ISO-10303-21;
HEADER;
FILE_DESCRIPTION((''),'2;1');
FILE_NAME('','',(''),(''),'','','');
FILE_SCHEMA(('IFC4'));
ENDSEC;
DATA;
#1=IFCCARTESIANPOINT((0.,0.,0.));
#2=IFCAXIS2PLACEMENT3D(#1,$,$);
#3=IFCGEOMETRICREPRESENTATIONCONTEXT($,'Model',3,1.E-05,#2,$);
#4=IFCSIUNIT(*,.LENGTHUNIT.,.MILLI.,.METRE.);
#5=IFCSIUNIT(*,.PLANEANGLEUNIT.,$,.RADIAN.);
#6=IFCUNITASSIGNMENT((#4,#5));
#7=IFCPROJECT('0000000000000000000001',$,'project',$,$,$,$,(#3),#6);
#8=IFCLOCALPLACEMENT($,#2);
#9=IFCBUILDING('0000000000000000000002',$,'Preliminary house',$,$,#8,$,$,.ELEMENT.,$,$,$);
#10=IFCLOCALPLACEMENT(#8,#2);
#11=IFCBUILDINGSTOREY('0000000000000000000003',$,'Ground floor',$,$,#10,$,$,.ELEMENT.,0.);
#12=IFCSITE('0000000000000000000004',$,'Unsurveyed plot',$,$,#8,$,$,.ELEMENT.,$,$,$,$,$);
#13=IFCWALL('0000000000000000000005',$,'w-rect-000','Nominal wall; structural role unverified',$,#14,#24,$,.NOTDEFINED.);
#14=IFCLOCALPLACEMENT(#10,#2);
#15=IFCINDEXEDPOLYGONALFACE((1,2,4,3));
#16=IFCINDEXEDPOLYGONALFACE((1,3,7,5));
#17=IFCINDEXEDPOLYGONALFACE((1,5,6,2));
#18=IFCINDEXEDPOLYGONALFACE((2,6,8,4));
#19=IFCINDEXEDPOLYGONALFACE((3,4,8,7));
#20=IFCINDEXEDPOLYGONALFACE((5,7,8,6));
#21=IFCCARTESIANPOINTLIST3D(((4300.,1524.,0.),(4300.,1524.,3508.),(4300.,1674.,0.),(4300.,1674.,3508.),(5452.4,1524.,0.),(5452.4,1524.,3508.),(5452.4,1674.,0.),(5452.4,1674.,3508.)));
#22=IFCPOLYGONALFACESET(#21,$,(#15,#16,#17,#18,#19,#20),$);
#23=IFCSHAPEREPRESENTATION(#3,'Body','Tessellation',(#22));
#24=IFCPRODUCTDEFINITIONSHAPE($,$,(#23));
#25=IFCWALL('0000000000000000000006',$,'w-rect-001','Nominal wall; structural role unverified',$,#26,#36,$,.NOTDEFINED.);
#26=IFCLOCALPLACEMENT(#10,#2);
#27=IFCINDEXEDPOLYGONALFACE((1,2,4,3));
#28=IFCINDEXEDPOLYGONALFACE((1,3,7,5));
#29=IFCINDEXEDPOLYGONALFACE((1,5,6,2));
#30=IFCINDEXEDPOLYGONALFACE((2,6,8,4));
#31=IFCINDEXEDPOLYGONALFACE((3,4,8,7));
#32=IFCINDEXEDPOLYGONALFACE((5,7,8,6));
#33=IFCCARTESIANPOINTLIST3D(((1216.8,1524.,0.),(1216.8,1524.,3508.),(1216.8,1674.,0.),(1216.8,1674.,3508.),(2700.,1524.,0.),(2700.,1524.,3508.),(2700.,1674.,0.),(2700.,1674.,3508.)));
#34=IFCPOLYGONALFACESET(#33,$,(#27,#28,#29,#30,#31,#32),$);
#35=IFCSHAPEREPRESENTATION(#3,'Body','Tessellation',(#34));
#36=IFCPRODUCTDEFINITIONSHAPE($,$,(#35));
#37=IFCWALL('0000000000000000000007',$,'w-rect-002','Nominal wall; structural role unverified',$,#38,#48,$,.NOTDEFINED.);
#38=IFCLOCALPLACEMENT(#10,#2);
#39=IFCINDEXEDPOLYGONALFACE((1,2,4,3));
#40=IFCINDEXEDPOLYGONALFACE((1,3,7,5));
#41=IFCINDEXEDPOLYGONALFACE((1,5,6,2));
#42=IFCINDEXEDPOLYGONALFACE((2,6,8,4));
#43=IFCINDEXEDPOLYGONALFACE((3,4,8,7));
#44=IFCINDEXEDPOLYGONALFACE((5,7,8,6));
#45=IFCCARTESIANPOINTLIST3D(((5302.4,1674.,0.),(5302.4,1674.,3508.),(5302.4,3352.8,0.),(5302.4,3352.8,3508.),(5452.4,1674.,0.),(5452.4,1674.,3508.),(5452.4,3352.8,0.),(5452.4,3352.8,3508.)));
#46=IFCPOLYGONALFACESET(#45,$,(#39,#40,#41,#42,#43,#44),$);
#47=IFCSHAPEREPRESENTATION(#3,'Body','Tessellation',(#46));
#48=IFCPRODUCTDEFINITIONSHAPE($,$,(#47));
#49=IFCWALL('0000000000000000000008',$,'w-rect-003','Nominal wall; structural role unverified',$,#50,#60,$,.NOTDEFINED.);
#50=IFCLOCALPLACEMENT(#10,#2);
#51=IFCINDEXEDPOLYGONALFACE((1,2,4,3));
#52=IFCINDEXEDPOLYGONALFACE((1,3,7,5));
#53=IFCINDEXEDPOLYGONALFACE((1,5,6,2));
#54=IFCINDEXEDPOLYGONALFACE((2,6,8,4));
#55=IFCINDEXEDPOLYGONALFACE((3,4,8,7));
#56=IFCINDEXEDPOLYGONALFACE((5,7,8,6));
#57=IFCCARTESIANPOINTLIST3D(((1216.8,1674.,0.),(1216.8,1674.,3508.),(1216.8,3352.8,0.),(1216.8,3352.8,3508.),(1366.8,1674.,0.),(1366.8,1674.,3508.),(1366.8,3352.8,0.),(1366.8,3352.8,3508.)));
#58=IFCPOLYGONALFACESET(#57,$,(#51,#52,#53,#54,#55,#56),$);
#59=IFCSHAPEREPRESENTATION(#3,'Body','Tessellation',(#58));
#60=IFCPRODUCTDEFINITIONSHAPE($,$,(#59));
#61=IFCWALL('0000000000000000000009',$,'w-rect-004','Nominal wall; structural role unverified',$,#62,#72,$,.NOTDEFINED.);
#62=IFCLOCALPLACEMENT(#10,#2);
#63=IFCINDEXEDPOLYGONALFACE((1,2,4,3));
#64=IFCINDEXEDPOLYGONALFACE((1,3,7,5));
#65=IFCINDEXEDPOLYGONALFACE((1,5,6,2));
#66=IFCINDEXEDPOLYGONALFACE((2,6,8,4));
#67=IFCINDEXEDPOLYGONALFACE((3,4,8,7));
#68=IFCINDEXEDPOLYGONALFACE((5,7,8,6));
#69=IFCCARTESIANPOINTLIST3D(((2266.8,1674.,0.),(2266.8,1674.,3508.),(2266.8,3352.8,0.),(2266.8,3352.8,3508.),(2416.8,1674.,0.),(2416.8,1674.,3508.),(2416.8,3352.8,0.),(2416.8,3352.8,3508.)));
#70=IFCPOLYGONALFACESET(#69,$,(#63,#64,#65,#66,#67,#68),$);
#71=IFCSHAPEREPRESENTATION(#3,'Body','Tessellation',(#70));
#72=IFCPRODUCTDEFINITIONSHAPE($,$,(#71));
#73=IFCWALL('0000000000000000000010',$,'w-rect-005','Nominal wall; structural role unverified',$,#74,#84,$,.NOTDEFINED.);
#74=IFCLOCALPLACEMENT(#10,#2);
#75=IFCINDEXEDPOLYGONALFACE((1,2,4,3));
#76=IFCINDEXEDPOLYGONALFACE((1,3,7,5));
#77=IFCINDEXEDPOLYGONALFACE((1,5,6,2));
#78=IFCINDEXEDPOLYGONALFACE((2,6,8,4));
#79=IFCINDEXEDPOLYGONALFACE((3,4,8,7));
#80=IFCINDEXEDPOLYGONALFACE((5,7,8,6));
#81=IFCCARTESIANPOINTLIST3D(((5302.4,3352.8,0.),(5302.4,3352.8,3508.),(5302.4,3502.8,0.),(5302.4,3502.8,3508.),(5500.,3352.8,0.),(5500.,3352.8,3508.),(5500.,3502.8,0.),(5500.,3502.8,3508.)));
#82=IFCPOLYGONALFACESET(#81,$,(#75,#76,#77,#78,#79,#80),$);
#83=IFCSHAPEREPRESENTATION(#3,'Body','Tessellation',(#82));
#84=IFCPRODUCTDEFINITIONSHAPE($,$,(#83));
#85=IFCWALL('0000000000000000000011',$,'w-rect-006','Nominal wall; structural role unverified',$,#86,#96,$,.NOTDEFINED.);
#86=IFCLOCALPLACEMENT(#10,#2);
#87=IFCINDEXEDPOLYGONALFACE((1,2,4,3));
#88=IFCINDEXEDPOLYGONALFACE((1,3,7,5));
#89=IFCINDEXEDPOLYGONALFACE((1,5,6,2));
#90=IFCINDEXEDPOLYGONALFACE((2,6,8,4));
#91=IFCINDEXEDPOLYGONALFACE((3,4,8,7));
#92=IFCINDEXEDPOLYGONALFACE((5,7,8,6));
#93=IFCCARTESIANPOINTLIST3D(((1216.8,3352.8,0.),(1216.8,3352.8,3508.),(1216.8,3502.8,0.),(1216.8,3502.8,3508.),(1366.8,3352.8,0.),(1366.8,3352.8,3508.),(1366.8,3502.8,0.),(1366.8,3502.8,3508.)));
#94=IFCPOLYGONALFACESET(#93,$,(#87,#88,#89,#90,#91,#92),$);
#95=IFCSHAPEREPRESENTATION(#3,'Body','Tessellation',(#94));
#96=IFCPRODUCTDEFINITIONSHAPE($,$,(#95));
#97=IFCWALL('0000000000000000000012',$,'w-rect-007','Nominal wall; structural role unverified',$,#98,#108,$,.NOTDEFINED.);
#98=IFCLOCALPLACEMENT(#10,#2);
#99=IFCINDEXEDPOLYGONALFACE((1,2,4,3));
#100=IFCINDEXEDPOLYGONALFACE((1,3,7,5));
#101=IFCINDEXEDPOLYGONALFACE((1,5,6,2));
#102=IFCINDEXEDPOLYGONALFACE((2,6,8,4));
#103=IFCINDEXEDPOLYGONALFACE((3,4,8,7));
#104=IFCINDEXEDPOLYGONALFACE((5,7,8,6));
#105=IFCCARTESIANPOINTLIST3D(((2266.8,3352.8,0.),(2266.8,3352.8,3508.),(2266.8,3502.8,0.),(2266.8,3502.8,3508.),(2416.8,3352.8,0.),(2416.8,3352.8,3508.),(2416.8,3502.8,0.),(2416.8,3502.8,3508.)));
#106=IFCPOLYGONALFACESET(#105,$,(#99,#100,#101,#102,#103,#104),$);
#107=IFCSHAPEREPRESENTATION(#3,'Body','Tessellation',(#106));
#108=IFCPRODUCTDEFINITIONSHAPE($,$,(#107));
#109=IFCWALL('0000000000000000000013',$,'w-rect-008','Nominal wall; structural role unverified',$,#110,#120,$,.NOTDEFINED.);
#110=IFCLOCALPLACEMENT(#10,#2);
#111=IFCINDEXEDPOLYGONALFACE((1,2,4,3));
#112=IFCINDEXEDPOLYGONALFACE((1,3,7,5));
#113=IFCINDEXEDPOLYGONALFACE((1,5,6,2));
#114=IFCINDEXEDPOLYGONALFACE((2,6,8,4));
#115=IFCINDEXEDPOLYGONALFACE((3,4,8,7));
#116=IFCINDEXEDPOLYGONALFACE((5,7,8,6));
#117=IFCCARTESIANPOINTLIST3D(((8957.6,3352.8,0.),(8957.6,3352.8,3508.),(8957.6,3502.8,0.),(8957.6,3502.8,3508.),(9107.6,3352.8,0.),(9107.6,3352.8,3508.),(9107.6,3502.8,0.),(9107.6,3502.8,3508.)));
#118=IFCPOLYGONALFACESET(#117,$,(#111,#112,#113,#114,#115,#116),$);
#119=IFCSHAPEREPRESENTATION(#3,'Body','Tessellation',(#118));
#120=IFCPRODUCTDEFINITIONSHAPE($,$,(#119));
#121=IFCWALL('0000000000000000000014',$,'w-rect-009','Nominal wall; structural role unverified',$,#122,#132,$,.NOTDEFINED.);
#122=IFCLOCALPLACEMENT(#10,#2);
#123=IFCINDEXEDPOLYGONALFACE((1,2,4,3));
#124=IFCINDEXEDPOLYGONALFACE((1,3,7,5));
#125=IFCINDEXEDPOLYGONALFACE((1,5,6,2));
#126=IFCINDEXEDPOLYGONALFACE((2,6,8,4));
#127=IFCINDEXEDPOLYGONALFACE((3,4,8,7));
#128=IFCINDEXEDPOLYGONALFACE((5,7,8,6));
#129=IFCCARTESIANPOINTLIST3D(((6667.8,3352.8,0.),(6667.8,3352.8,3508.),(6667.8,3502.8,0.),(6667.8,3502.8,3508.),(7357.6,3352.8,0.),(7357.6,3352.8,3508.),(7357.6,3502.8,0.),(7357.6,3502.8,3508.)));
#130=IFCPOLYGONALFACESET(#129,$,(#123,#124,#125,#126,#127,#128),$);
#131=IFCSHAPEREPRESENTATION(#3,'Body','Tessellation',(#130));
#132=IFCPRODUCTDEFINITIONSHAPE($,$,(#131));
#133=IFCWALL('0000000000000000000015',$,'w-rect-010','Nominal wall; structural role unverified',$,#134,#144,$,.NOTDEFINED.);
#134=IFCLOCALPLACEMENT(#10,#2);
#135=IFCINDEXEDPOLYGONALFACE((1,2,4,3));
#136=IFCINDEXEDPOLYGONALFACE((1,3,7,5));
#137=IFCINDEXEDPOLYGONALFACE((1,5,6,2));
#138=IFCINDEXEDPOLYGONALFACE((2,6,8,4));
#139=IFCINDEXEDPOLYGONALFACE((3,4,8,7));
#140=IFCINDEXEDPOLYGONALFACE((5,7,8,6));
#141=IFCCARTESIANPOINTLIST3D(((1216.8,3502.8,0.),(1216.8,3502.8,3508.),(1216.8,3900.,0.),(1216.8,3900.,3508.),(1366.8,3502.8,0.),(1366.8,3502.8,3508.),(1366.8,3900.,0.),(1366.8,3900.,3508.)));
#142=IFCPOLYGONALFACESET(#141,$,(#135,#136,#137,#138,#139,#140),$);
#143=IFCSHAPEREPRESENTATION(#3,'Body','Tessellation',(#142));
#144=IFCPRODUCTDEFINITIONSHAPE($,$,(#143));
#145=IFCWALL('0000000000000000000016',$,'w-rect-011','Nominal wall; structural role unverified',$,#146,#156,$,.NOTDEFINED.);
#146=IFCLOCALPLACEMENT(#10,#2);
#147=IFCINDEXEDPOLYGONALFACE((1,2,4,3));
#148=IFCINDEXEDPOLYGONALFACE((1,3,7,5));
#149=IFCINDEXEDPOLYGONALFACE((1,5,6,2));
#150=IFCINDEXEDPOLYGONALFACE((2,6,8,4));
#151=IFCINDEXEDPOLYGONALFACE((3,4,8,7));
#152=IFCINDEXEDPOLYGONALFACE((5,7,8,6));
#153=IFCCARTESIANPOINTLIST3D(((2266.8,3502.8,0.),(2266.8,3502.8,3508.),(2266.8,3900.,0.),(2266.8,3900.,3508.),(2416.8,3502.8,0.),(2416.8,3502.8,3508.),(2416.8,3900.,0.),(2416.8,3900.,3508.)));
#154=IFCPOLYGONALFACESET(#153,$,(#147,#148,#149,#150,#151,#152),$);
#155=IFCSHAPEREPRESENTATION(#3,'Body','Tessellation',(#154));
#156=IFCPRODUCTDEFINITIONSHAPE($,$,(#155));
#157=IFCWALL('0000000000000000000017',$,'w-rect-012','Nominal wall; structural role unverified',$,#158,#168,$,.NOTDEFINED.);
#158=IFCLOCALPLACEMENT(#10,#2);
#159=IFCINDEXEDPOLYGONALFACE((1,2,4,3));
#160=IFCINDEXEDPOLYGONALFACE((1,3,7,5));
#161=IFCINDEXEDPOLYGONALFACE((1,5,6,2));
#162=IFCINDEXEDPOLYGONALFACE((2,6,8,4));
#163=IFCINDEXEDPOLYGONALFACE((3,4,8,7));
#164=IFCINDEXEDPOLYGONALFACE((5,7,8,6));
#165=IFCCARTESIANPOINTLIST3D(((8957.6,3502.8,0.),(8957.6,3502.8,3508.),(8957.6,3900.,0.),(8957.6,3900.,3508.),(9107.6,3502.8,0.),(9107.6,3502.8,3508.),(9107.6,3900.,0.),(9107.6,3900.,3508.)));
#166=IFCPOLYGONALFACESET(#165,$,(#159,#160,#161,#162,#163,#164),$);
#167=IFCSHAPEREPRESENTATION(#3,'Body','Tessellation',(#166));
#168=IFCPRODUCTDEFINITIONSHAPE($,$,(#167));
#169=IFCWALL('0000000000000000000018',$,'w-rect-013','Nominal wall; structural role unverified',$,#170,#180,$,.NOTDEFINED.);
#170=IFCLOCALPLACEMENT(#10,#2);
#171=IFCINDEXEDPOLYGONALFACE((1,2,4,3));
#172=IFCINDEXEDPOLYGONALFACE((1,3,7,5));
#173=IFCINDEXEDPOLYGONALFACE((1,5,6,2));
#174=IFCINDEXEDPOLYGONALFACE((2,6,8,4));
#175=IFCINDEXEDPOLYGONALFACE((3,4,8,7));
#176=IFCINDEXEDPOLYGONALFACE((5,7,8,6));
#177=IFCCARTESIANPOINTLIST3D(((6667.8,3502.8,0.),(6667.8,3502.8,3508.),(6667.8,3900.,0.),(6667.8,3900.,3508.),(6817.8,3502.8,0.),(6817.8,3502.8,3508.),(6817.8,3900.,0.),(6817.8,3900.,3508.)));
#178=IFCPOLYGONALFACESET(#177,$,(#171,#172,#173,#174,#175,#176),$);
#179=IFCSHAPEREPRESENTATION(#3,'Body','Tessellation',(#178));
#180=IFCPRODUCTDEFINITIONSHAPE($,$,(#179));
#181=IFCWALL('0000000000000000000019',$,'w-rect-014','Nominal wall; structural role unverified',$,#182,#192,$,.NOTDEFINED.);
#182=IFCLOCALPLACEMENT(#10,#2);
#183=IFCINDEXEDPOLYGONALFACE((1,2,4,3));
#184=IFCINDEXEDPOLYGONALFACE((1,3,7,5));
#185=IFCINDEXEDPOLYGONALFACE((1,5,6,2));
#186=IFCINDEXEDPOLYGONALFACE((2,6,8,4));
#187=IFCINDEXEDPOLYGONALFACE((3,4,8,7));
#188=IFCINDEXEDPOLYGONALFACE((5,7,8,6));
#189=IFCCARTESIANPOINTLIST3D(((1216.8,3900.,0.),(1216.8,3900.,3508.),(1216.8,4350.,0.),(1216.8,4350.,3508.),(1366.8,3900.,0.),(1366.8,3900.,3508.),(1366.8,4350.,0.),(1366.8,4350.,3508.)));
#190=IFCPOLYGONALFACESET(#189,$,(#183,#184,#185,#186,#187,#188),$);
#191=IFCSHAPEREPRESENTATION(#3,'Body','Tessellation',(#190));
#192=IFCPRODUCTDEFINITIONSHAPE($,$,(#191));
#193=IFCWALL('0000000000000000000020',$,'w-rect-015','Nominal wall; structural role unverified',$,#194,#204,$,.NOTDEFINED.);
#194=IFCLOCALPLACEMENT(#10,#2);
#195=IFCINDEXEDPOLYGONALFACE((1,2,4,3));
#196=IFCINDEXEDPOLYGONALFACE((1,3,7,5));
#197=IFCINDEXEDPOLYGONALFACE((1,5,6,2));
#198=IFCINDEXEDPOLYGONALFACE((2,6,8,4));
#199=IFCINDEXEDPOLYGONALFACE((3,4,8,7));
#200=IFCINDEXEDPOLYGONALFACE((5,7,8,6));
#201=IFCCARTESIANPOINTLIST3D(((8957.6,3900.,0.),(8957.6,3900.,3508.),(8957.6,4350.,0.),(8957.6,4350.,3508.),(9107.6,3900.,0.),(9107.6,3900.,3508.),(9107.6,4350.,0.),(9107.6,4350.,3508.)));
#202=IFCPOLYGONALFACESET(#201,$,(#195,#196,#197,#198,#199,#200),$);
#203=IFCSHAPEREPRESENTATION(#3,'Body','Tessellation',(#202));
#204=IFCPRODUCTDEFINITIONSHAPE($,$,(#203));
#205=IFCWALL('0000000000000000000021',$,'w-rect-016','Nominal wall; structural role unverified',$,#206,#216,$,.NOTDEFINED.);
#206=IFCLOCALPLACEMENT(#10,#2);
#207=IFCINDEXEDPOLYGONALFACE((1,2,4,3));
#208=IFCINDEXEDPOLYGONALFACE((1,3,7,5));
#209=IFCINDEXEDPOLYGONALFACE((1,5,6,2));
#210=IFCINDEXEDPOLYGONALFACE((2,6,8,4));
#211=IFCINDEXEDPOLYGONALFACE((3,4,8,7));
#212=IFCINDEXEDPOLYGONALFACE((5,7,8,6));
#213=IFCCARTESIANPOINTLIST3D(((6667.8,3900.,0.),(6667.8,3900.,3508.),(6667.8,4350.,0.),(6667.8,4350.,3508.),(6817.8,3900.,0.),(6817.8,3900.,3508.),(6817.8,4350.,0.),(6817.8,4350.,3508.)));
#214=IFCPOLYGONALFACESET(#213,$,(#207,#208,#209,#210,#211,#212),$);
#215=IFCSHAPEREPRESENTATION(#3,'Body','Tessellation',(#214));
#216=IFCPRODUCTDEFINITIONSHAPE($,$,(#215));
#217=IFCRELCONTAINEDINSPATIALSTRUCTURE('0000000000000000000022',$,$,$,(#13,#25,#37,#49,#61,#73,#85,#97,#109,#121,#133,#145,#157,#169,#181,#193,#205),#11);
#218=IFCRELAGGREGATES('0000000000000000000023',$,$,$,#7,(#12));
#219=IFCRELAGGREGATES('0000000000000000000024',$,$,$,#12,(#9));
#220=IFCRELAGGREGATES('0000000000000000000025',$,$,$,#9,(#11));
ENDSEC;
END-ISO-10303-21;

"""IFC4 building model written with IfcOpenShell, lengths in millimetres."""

from ifc_helpers import new_model, si_unit, origin, place, context, project, spatial, polyline, outline, extrude, element, save


model = new_model("IFC4")

# Units and contexts
model_context = context("Model", 3, precision=1e-05, world=origin())
ifc_project = project(units=[si_unit("LENGTHUNIT", "METRE", prefix="MILLI"), si_unit("PLANEANGLEUNIT", "RADIAN")], contexts=[model_context])

# Site, building, storey
placement_1 = place(None, origin())
site = spatial("IfcSite", under=ifc_project, at=placement_1, Name="Unsurveyed plot", CompositionType="ELEMENT")
building = spatial("IfcBuilding", under=site, at=placement_1, Name="Preliminary house", CompositionType="ELEMENT")
placement_2 = place(placement_1, origin())
storey = spatial("IfcBuildingStorey", under=building, at=placement_2, Name="Ground floor", CompositionType="ELEMENT", Elevation=0.0)

# Walls
element("IfcWall", 1, at=placement_2, inside=storey, Name="w-rect-000", Description="Nominal wall; structural role unverified", PredefinedType="NOTDEFINED", context=model_context, shape_type="SweptSolid", body=[
    extrude(outline(polyline([(4300.0, 1524.0), (5452.4, 1524.0), (5452.4, 1674.0), (4300.0, 1674.0), (4300.0, 1524.0)])), origin(), (0.0, 0.0, 1.0), 3508.0),
])
element("IfcWall", 2, at=placement_2, inside=storey, Name="w-rect-001", Description="Nominal wall; structural role unverified", PredefinedType="NOTDEFINED", context=model_context, shape_type="SweptSolid", body=[
    extrude(outline(polyline([(1216.8, 1524.0), (2700.0, 1524.0), (2700.0, 1674.0), (1216.8, 1674.0), (1216.8, 1524.0)])), origin(), (0.0, 0.0, 1.0), 3508.0),
])
element("IfcWall", 3, at=placement_2, inside=storey, Name="w-rect-002", Description="Nominal wall; structural role unverified", PredefinedType="NOTDEFINED", context=model_context, shape_type="SweptSolid", body=[
    extrude(outline(polyline([(5302.4, 1674.0), (5452.4, 1674.0), (5452.4, 3352.8), (5302.4, 3352.8), (5302.4, 1674.0)])), origin(), (0.0, 0.0, 1.0), 3508.0),
])
element("IfcWall", 4, at=placement_2, inside=storey, Name="w-rect-003", Description="Nominal wall; structural role unverified", PredefinedType="NOTDEFINED", context=model_context, shape_type="SweptSolid", body=[
    extrude(outline(polyline([(1216.8, 1674.0), (1366.8, 1674.0), (1366.8, 3352.8), (1216.8, 3352.8), (1216.8, 1674.0)])), origin(), (0.0, 0.0, 1.0), 3508.0),
])
element("IfcWall", 5, at=placement_2, inside=storey, Name="w-rect-004", Description="Nominal wall; structural role unverified", PredefinedType="NOTDEFINED", context=model_context, shape_type="SweptSolid", body=[
    extrude(outline(polyline([(2266.8, 1674.0), (2416.8, 1674.0), (2416.8, 3352.8), (2266.8, 3352.8), (2266.8, 1674.0)])), origin(), (0.0, 0.0, 1.0), 3508.0),
])
element("IfcWall", 6, at=placement_2, inside=storey, Name="w-rect-005", Description="Nominal wall; structural role unverified", PredefinedType="NOTDEFINED", context=model_context, shape_type="SweptSolid", body=[
    extrude(outline(polyline([(5302.4, 3352.8), (5500.0, 3352.8), (5500.0, 3502.8), (5302.4, 3502.8), (5302.4, 3352.8)])), origin(), (0.0, 0.0, 1.0), 3508.0),
])
element("IfcWall", 7, at=placement_2, inside=storey, Name="w-rect-006", Description="Nominal wall; structural role unverified", PredefinedType="NOTDEFINED", context=model_context, shape_type="SweptSolid", body=[
    extrude(outline(polyline([(1216.8, 3352.8), (1366.8, 3352.8), (1366.8, 3502.8), (1216.8, 3502.8), (1216.8, 3352.8)])), origin(), (0.0, 0.0, 1.0), 3508.0),
])
element("IfcWall", 8, at=placement_2, inside=storey, Name="w-rect-007", Description="Nominal wall; structural role unverified", PredefinedType="NOTDEFINED", context=model_context, shape_type="SweptSolid", body=[
    extrude(outline(polyline([(2266.8, 3352.8), (2416.8, 3352.8), (2416.8, 3502.8), (2266.8, 3502.8), (2266.8, 3352.8)])), origin(), (0.0, 0.0, 1.0), 3508.0),
])
element("IfcWall", 9, at=placement_2, inside=storey, Name="w-rect-008", Description="Nominal wall; structural role unverified", PredefinedType="NOTDEFINED", context=model_context, shape_type="SweptSolid", body=[
    extrude(outline(polyline([(8957.6, 3352.8), (9107.6, 3352.8), (9107.6, 3502.8), (8957.6, 3502.8), (8957.6, 3352.8)])), origin(), (0.0, 0.0, 1.0), 3508.0),
])
element("IfcWall", 10, at=placement_2, inside=storey, Name="w-rect-009", Description="Nominal wall; structural role unverified", PredefinedType="NOTDEFINED", context=model_context, shape_type="SweptSolid", body=[
    extrude(outline(polyline([(6667.8, 3352.8), (7357.6, 3352.8), (7357.6, 3502.8), (6667.8, 3502.8), (6667.8, 3352.8)])), origin(), (0.0, 0.0, 1.0), 3508.0),
])
element("IfcWall", 11, at=placement_2, inside=storey, Name="w-rect-010", Description="Nominal wall; structural role unverified", PredefinedType="NOTDEFINED", context=model_context, shape_type="SweptSolid", body=[
    extrude(outline(polyline([(1216.8, 3502.8), (1366.8, 3502.8), (1366.8, 3900.0), (1216.8, 3900.0), (1216.8, 3502.8)])), origin(), (0.0, 0.0, 1.0), 3508.0),
])
element("IfcWall", 12, at=placement_2, inside=storey, Name="w-rect-011", Description="Nominal wall; structural role unverified", PredefinedType="NOTDEFINED", context=model_context, shape_type="SweptSolid", body=[
    extrude(outline(polyline([(2266.8, 3502.8), (2416.8, 3502.8), (2416.8, 3900.0), (2266.8, 3900.0), (2266.8, 3502.8)])), origin(), (0.0, 0.0, 1.0), 3508.0),
])
element("IfcWall", 13, at=placement_2, inside=storey, Name="w-rect-012", Description="Nominal wall; structural role unverified", PredefinedType="NOTDEFINED", context=model_context, shape_type="SweptSolid", body=[
    extrude(outline(polyline([(8957.6, 3502.8), (9107.6, 3502.8), (9107.6, 3900.0), (8957.6, 3900.0), (8957.6, 3502.8)])), origin(), (0.0, 0.0, 1.0), 3508.0),
])
element("IfcWall", 14, at=placement_2, inside=storey, Name="w-rect-013", Description="Nominal wall; structural role unverified", PredefinedType="NOTDEFINED", context=model_context, shape_type="SweptSolid", body=[
    extrude(outline(polyline([(6667.8, 3502.8), (6817.8, 3502.8), (6817.8, 3900.0), (6667.8, 3900.0), (6667.8, 3502.8)])), origin(), (0.0, 0.0, 1.0), 3508.0),
])
element("IfcWall", 15, at=placement_2, inside=storey, Name="w-rect-014", Description="Nominal wall; structural role unverified", PredefinedType="NOTDEFINED", context=model_context, shape_type="SweptSolid", body=[
    extrude(outline(polyline([(1216.8, 3900.0), (1366.8, 3900.0), (1366.8, 4350.0), (1216.8, 4350.0), (1216.8, 3900.0)])), origin(), (0.0, 0.0, 1.0), 3508.0),
])
element("IfcWall", 16, at=placement_2, inside=storey, Name="w-rect-015", Description="Nominal wall; structural role unverified", PredefinedType="NOTDEFINED", context=model_context, shape_type="SweptSolid", body=[
    extrude(outline(polyline([(8957.6, 3900.0), (9107.6, 3900.0), (9107.6, 4350.0), (8957.6, 4350.0), (8957.6, 3900.0)])), origin(), (0.0, 0.0, 1.0), 3508.0),
])
element("IfcWall", 17, at=placement_2, inside=storey, Name="w-rect-016", Description="Nominal wall; structural role unverified", PredefinedType="NOTDEFINED", context=model_context, shape_type="SweptSolid", body=[
    extrude(outline(polyline([(6667.8, 3900.0), (6817.8, 3900.0), (6817.8, 4350.0), (6667.8, 4350.0), (6667.8, 3900.0)])), origin(), (0.0, 0.0, 1.0), 3508.0),
])

save(model, "model.ifc")
